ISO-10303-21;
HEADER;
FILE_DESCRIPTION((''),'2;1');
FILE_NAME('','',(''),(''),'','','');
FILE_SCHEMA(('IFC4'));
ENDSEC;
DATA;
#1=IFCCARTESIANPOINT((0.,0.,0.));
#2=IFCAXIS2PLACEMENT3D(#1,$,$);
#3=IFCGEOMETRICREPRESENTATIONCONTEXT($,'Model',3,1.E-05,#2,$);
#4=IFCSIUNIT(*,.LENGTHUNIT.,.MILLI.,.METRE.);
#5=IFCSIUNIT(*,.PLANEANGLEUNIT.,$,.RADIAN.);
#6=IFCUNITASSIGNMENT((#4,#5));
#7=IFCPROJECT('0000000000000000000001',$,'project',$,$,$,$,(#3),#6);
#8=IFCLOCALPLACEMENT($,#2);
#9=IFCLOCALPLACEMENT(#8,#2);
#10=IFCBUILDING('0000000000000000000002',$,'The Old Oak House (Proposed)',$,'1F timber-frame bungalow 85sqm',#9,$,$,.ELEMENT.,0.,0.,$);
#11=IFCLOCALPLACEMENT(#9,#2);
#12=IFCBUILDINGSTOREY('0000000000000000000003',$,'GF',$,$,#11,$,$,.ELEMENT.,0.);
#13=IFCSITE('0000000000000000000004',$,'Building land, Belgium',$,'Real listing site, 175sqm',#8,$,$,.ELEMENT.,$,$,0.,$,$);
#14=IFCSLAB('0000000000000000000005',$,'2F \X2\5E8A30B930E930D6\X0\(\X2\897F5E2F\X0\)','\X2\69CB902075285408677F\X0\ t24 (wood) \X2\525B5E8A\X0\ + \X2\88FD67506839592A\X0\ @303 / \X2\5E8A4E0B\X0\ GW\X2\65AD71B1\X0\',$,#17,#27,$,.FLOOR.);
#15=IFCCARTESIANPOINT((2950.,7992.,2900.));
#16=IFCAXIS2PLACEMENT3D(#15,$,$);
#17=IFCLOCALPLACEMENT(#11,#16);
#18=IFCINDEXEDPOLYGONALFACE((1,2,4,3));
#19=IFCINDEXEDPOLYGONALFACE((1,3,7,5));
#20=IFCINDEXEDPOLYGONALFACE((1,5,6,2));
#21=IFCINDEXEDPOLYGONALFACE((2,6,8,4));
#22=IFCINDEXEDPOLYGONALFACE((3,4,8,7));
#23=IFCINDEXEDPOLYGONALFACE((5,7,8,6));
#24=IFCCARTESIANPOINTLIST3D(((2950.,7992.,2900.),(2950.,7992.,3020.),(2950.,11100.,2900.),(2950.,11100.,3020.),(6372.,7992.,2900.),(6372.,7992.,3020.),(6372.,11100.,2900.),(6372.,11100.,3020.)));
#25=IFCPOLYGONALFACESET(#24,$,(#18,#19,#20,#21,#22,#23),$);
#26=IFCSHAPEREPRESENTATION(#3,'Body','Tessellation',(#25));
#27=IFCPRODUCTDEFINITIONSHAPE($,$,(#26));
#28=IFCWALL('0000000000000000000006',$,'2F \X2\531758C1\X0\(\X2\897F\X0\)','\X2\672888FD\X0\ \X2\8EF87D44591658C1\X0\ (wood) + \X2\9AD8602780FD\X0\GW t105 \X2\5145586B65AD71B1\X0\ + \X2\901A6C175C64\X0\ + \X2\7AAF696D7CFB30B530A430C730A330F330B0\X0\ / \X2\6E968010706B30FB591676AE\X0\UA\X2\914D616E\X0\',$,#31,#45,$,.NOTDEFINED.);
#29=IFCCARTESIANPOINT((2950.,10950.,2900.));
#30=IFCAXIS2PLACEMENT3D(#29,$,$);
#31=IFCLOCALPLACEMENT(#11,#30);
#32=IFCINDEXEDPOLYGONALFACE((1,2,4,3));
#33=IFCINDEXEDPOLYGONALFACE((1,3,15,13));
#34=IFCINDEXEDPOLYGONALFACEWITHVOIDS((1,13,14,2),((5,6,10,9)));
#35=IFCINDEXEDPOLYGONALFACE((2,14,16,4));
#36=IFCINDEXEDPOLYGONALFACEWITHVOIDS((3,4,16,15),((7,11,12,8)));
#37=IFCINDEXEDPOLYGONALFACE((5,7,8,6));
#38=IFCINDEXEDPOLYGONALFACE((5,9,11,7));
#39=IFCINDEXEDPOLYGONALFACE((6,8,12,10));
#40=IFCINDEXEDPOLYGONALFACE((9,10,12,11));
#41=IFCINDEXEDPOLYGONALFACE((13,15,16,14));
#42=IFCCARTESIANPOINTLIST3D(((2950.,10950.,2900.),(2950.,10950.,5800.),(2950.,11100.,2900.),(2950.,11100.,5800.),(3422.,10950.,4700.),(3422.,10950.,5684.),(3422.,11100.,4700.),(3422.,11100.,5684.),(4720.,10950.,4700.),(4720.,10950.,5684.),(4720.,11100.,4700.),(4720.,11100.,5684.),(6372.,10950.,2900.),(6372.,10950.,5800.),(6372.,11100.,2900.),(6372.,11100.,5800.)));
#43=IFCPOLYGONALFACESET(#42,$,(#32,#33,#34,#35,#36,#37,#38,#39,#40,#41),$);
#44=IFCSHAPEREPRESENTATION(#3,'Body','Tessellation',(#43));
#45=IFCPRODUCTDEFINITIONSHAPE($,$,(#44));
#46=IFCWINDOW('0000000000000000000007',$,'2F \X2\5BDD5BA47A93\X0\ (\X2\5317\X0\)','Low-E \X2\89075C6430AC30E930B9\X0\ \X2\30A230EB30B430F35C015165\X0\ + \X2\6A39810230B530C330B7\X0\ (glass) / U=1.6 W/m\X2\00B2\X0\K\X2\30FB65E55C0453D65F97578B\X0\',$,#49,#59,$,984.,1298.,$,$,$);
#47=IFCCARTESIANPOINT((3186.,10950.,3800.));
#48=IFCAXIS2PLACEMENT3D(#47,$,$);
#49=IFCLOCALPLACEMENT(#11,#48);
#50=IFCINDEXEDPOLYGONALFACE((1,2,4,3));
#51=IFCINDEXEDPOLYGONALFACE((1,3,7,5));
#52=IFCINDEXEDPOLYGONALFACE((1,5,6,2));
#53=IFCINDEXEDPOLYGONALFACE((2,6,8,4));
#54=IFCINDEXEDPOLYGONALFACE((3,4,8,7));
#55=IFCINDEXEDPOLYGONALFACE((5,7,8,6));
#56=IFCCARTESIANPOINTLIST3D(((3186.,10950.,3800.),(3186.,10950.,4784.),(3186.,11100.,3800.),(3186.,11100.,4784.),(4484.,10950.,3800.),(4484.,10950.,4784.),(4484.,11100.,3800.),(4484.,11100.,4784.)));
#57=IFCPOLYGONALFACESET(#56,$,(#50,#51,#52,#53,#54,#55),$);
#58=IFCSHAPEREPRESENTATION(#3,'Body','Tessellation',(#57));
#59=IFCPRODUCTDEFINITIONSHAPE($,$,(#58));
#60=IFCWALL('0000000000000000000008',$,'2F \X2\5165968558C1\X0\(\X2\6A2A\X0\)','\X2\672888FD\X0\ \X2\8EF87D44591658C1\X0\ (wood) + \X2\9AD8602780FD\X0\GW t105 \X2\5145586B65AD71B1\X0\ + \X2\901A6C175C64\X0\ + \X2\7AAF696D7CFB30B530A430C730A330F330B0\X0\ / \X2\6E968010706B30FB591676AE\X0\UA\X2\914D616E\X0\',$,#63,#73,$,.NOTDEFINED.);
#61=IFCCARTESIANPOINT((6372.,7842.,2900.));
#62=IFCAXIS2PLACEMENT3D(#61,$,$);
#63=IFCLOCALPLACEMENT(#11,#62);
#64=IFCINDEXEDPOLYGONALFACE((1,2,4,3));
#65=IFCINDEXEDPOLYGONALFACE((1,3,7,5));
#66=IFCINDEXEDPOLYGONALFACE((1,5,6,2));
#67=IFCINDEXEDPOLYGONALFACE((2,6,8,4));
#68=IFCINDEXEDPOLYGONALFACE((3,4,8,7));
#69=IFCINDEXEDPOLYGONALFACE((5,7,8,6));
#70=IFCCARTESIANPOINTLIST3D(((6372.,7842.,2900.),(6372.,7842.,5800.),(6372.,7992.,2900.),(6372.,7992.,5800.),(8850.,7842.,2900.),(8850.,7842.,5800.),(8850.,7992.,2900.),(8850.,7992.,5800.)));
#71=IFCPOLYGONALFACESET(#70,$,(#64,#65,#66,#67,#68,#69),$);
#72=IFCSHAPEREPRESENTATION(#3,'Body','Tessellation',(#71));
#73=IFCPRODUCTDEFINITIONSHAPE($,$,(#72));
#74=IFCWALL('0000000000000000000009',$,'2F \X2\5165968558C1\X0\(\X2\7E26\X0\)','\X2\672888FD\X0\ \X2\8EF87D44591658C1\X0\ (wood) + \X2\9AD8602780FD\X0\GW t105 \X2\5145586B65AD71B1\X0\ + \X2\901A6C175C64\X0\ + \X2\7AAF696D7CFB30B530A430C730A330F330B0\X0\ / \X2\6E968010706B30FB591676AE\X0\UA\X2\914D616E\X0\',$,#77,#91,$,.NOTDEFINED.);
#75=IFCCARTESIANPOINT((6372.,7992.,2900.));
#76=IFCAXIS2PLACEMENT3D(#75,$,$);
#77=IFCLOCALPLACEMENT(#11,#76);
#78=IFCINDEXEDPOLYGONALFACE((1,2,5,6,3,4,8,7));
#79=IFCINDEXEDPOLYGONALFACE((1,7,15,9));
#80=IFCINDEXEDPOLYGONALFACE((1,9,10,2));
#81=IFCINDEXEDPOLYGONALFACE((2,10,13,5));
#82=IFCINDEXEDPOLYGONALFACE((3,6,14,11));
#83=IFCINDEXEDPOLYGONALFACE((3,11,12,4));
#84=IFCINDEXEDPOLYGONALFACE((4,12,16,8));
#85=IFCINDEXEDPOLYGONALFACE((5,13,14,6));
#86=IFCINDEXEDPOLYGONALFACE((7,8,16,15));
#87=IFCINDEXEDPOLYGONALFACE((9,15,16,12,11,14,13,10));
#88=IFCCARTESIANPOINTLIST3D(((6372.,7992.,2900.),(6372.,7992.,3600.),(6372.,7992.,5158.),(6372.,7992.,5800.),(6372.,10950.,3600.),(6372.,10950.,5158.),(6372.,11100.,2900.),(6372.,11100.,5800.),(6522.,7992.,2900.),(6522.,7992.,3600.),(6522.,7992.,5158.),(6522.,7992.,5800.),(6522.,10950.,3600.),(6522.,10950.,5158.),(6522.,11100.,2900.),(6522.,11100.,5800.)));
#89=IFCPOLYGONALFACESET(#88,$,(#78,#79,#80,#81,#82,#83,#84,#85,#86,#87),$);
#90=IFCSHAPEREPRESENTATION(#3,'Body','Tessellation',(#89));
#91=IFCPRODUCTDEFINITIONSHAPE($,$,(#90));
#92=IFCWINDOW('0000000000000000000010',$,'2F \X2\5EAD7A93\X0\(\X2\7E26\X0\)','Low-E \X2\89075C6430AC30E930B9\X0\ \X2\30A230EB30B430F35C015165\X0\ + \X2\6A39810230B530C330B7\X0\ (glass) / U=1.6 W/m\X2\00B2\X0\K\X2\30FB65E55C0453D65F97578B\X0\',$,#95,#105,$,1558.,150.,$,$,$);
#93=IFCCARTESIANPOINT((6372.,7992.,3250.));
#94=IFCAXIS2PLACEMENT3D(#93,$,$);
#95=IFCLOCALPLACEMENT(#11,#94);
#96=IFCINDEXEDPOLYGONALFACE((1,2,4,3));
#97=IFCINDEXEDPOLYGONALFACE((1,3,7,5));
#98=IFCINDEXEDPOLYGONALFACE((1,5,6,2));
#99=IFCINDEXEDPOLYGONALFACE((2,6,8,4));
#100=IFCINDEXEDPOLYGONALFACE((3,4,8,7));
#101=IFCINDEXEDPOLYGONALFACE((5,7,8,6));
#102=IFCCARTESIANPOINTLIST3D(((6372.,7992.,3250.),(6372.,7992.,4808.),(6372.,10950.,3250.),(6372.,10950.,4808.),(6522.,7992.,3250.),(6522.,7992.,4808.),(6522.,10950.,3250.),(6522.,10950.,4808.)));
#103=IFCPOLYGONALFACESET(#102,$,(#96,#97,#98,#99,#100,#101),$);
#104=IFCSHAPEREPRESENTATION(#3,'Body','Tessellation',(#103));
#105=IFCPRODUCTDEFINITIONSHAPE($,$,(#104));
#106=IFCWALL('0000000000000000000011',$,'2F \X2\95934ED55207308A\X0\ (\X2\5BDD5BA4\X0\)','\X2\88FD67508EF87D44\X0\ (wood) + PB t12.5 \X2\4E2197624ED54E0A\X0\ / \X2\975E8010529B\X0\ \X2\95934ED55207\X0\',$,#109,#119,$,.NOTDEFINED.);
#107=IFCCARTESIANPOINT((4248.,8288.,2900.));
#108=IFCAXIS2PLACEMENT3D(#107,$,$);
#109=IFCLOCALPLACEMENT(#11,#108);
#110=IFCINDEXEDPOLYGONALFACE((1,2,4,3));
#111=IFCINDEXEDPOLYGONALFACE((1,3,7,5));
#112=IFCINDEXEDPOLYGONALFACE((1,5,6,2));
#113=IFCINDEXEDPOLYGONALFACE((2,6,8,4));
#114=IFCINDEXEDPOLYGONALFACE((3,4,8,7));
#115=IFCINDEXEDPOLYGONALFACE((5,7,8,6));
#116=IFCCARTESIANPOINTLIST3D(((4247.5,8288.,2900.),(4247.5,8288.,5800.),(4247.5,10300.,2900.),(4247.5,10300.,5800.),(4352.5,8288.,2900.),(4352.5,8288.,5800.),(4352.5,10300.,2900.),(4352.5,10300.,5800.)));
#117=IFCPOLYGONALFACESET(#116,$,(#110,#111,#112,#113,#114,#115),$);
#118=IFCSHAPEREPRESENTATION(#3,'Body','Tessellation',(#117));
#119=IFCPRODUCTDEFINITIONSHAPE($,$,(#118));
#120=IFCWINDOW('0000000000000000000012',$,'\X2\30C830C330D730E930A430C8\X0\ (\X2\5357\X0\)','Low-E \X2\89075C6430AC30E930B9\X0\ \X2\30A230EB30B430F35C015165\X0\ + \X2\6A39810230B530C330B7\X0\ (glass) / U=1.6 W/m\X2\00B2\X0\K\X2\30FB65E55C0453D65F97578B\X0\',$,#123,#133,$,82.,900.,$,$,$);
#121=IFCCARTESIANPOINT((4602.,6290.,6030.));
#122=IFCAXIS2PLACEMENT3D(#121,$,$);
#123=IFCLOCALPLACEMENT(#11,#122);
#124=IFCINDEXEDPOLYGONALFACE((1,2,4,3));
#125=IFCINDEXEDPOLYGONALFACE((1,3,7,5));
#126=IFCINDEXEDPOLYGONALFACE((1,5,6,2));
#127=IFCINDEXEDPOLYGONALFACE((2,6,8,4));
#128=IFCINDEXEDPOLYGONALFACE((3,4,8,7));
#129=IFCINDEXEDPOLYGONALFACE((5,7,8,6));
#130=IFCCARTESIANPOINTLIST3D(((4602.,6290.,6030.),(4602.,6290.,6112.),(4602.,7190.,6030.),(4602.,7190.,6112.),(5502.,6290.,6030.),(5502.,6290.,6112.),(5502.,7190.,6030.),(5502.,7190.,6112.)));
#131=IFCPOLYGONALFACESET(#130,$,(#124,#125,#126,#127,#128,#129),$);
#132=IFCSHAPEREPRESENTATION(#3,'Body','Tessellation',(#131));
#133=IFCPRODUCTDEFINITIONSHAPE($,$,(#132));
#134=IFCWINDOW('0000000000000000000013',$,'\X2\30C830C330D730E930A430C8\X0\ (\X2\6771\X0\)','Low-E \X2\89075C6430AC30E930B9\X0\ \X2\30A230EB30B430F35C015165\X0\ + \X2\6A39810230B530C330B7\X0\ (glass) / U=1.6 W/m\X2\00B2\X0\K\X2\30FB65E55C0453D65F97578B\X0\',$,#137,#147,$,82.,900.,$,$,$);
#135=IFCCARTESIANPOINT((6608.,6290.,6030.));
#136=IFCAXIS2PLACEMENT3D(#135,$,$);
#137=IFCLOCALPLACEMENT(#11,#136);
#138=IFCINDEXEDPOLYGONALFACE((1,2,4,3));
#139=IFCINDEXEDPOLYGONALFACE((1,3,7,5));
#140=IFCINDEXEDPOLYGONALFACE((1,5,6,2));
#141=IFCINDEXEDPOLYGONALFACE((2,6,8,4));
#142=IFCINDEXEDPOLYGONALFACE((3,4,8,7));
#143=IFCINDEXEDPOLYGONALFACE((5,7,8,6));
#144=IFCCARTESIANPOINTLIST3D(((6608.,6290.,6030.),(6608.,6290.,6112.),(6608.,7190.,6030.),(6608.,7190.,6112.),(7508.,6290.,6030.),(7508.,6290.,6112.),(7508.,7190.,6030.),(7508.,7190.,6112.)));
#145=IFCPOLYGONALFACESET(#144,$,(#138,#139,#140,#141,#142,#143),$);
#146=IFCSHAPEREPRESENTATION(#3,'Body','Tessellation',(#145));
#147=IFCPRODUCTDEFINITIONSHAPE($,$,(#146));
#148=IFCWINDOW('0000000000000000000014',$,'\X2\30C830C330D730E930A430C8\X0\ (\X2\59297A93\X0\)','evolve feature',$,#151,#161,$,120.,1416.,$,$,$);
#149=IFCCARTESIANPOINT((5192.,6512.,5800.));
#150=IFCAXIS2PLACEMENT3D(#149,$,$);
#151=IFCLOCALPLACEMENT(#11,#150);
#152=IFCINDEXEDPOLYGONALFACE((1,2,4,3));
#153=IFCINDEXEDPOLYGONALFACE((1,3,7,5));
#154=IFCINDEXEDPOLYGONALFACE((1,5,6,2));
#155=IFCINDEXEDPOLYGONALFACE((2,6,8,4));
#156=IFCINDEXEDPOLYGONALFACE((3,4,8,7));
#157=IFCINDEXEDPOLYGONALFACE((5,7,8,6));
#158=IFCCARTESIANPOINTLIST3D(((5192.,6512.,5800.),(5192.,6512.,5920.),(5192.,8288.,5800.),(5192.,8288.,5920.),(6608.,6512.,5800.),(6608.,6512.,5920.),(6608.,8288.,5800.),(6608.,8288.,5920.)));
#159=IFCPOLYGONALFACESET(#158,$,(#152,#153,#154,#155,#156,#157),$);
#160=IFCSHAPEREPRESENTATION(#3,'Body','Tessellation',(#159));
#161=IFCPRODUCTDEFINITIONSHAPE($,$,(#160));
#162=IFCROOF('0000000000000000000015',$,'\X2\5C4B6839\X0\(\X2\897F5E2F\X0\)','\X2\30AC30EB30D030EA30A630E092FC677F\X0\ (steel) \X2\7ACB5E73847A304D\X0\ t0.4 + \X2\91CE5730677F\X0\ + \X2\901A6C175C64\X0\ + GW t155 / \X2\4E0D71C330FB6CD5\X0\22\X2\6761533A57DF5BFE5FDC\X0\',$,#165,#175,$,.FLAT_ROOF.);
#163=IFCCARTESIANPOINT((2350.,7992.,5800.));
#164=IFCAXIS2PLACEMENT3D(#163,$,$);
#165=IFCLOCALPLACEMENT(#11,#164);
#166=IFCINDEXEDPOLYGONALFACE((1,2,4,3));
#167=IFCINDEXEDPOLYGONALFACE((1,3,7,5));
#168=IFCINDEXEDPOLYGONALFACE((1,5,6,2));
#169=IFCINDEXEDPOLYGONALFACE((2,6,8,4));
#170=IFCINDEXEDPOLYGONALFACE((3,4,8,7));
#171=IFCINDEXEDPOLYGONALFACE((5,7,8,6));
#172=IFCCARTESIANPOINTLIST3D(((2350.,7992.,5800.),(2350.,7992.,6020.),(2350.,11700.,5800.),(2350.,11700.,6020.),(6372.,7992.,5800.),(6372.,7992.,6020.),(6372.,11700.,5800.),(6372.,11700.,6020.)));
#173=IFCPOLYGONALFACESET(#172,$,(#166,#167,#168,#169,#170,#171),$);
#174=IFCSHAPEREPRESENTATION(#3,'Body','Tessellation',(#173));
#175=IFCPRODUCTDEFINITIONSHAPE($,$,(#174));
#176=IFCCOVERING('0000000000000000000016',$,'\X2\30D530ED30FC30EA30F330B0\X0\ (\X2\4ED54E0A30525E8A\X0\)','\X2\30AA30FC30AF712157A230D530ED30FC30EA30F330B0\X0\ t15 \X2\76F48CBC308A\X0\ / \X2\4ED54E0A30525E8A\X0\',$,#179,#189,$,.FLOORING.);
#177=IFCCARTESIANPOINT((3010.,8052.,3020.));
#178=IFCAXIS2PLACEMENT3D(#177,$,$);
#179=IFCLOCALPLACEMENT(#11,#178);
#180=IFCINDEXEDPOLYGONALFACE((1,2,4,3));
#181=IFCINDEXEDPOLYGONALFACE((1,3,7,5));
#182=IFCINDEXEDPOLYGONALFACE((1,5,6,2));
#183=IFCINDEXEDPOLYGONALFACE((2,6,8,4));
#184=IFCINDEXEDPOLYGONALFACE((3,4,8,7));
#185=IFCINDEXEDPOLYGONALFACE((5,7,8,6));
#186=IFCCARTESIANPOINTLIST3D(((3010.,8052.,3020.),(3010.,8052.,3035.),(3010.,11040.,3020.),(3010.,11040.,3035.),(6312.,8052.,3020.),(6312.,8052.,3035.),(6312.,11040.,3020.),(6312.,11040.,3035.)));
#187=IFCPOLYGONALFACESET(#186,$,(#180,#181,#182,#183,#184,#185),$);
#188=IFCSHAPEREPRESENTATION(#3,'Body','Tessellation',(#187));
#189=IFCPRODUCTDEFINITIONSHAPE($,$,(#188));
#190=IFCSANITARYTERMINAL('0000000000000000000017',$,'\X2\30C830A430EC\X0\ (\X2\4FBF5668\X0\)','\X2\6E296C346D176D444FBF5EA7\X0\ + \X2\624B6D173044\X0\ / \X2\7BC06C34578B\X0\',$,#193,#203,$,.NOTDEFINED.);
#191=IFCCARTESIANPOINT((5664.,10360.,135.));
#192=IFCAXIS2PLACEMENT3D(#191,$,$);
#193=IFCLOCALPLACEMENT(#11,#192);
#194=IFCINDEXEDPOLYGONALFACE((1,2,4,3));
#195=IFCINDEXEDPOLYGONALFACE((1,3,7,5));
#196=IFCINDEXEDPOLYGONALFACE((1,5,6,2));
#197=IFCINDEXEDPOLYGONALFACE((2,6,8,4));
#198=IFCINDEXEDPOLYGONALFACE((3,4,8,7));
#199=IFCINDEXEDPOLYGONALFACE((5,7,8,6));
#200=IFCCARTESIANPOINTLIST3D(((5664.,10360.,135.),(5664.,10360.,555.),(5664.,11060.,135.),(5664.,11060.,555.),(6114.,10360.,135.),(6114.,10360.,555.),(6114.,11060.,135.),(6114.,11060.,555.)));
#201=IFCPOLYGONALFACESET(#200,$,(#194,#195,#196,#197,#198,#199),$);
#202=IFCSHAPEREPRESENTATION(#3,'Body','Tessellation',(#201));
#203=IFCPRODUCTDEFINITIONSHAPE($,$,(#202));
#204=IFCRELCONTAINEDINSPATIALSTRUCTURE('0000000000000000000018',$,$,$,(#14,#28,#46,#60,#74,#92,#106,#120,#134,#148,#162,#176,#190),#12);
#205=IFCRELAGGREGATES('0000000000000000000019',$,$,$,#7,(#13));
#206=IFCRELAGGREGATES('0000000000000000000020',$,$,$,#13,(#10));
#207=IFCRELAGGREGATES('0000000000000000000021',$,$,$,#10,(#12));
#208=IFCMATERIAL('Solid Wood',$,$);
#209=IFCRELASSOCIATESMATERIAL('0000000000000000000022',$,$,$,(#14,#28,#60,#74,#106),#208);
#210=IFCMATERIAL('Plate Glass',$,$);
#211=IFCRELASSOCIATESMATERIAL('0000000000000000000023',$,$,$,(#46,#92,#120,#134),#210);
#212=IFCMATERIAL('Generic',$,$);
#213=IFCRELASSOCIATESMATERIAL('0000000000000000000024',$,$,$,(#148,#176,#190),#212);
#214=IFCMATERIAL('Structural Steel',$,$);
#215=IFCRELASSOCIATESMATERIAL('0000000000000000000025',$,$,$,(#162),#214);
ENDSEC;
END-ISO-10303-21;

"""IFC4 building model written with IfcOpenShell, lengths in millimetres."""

from ifc_helpers import new_model, si_unit, frame, frame_2d, origin, place, context, project, spatial, rectangle, extrude, material, element, fill, save


model = new_model("IFC4")

# Units and contexts
model_context = context("Model", 3, precision=1e-05, world=origin())
ifc_project = project(units=[si_unit("LENGTHUNIT", "METRE", prefix="MILLI"), si_unit("PLANEANGLEUNIT", "RADIAN")], contexts=[model_context])

# Site, building, storey
site_placement = place(None, origin())
site = spatial("IfcSite", under=ifc_project, at=site_placement, Name="Building land, Belgium", ObjectType="Real listing site, 175sqm", CompositionType="ELEMENT", RefElevation=0.0)
building_placement = place(site_placement, origin())
building = spatial("IfcBuilding", under=site, at=building_placement, Name="The Old Oak House (Proposed)", ObjectType="1F timber-frame bungalow 85sqm", CompositionType="ELEMENT", ElevationOfRefHeight=0.0, ElevationOfTerrain=0.0)
storey_placement = place(building_placement, origin())
storey = spatial("IfcBuildingStorey", under=building, at=storey_placement, Name="GF", CompositionType="ELEMENT", Elevation=0.0)

# Slab
ifc_material_1 = material(Name="Solid Wood")
slab_placement = place(storey_placement, frame((2950.0, 7992.0, 2900.0)))
element("IfcSlab", 1, at=slab_placement, inside=storey, material=ifc_material_1, Name="2F 床スラブ(西帯)", Description="構造用合板 t24 (wood) 剛床 + 製材根太 @303 / 床下 GW断熱", PredefinedType="FLOOR", context=model_context, shape_type="SweptSolid", body=[
    extrude(rectangle(XDim=3422.0, YDim=3108.0, at=frame_2d((1711.0, 1554.0))), frame((2950.0, 7992.0, 2900.0)), (0.0, 0.0, 1.0), 120.0),
])

# Wall, opening, window
wall_1_placement = place(storey_placement, frame((2950.0, 10950.0, 2900.0)))
wall_1 = element("IfcWall", 2, at=wall_1_placement, inside=storey, material=ifc_material_1, Name="2F 北壁(西)", Description="木製 軸組外壁 (wood) + 高性能GW t105 充填断熱 + 通気層 + 窯業系サイディング / 準耐火・外皮UA配慮", PredefinedType="NOTDEFINED", context=model_context, shape_type="SweptSolid", body=[
    extrude(rectangle(XDim=3422.0, YDim=150.0, at=frame_2d((1711.0, 75.0))), frame((2950.0, 10950.0, 2900.0)), (0.0, 0.0, 1.0), 2900.0),
])
opening_1_placement = place(storey_placement, frame((3186.0, 10950.0, 3800.0)))
opening_1 = element("IfcOpeningElement", 3, at=opening_1_placement, cuts=wall_1, PredefinedType="NOTDEFINED", context=model_context, shape_type="SweptSolid", body=[
    extrude(rectangle(XDim=1298.0, YDim=150.0, at=frame_2d((649.0, 75.0))), frame((3186.0, 10950.0, 3800.0)), (0.0, 0.0, 1.0), 984.0),
])
ifc_material_2 = material(Name="Plate Glass")
window_1_placement = place(storey_placement, frame((3186.0, 10950.0, 3800.0)))
window_1 = element("IfcWindow", 4, at=window_1_placement, inside=storey, material=ifc_material_2, Name="2F 寝室窓 (北)", Description="Low-E 複層ガラス アルゴン封入 + 樹脂サッシ (glass) / U=1.6 W/m²K・日射取得型", OverallHeight=984.0, OverallWidth=1298.0, context=model_context, shape_type="SweptSolid", body=[
    extrude(rectangle(XDim=1298.0, YDim=150.0, at=frame_2d((649.0, 75.0))), frame((3186.0, 10950.0, 3800.0)), (0.0, 0.0, 1.0), 984.0),
])
fill(opening_1, window_1)

# Wall
wall_2_placement = place(storey_placement, frame((6372.0, 7842.0, 2900.0)))
element("IfcWall", 5, at=wall_2_placement, inside=storey, material=ifc_material_1, Name="2F 入隅壁(横)", Description="木製 軸組外壁 (wood) + 高性能GW t105 充填断熱 + 通気層 + 窯業系サイディング / 準耐火・外皮UA配慮", PredefinedType="NOTDEFINED", context=model_context, shape_type="SweptSolid", body=[
    extrude(rectangle(XDim=2478.0, YDim=150.0, at=frame_2d((1239.0, 75.0))), frame((6372.0, 7842.0, 2900.0)), (0.0, 0.0, 1.0), 2900.0),
])

# Wall, opening, window
wall_3_placement = place(storey_placement, frame((6372.0, 7992.0, 2900.0)))
wall_3 = element("IfcWall", 6, at=wall_3_placement, inside=storey, material=ifc_material_1, Name="2F 入隅壁(縦)", Description="木製 軸組外壁 (wood) + 高性能GW t105 充填断熱 + 通気層 + 窯業系サイディング / 準耐火・外皮UA配慮", PredefinedType="NOTDEFINED", context=model_context, shape_type="SweptSolid", body=[
    extrude(rectangle(XDim=150.0, YDim=3108.0, at=frame_2d((75.0, 1554.0))), frame((6372.0, 7992.0, 2900.0)), (0.0, 0.0, 1.0), 2900.0),
])
opening_2_placement = place(storey_placement, frame((6372.0, 7992.0, 3250.0)))
opening_2 = element("IfcOpeningElement", 7, at=opening_2_placement, cuts=wall_3, PredefinedType="NOTDEFINED", context=model_context, shape_type="SweptSolid", body=[
    extrude(rectangle(XDim=150.0, YDim=2958.0, at=frame_2d((75.0, 1479.0))), frame((6372.0, 7992.0, 3250.0)), (0.0, 0.0, 1.0), 1558.0),
])
window_2_placement = place(storey_placement, frame((6372.0, 7992.0, 3250.0)))
window_2 = element("IfcWindow", 8, at=window_2_placement, inside=storey, material=ifc_material_2, Name="2F 庭窓(縦)", Description="Low-E 複層ガラス アルゴン封入 + 樹脂サッシ (glass) / U=1.6 W/m²K・日射取得型", OverallHeight=1558.0, OverallWidth=150.0, context=model_context, shape_type="SweptSolid", body=[
    extrude(rectangle(XDim=150.0, YDim=2958.0, at=frame_2d((75.0, 1479.0))), frame((6372.0, 7992.0, 3250.0)), (0.0, 0.0, 1.0), 1558.0),
])
fill(opening_2, window_2)

# Wall
wall_4_placement = place(storey_placement, frame((4248.0, 8288.0, 2900.0)))
element("IfcWall", 9, at=wall_4_placement, inside=storey, material=ifc_material_1, Name="2F 間仕切り (寝室)", Description="製材軸組 (wood) + PB t12.5 両面仕上 / 非耐力 間仕切", PredefinedType="NOTDEFINED", context=model_context, shape_type="SweptSolid", body=[
    extrude(rectangle(XDim=105.0, YDim=2012.0, at=frame_2d((52.0, 1006.0))), frame((4248.0, 8288.0, 2900.0)), (0.0, 0.0, 1.0), 2900.0),
])

# Windows
window_3_placement = place(storey_placement, frame((4602.0, 6290.0, 6030.0)))
element("IfcWindow", 10, at=window_3_placement, inside=storey, material=ifc_material_2, Name="トップライト (南)", Description="Low-E 複層ガラス アルゴン封入 + 樹脂サッシ (glass) / U=1.6 W/m²K・日射取得型", OverallHeight=82.0, OverallWidth=900.0, context=model_context, shape_type="SweptSolid", body=[
    extrude(rectangle(XDim=900.0, YDim=900.0, at=frame_2d((450.0, 450.0))), frame((4602.0, 6290.0, 6030.0)), (0.0, 0.0, 1.0), 82.0),
])
window_4_placement = place(storey_placement, frame((6608.0, 6290.0, 6030.0)))
element("IfcWindow", 11, at=window_4_placement, inside=storey, material=ifc_material_2, Name="トップライト (東)", Description="Low-E 複層ガラス アルゴン封入 + 樹脂サッシ (glass) / U=1.6 W/m²K・日射取得型", OverallHeight=82.0, OverallWidth=900.0, context=model_context, shape_type="SweptSolid", body=[
    extrude(rectangle(XDim=900.0, YDim=900.0, at=frame_2d((450.0, 450.0))), frame((6608.0, 6290.0, 6030.0)), (0.0, 0.0, 1.0), 82.0),
])
ifc_material_3 = material(Name="Generic")
window_5_placement = place(storey_placement, frame((5192.0, 6512.0, 5800.0)))
element("IfcWindow", 12, at=window_5_placement, inside=storey, material=ifc_material_3, Name="トップライト (天窓)", Description="evolve feature", OverallHeight=120.0, OverallWidth=1416.0, context=model_context, shape_type="SweptSolid", body=[
    extrude(rectangle(XDim=1416.0, YDim=1776.0, at=frame_2d((708.0, 888.0))), frame((5192.0, 6512.0, 5800.0)), (0.0, 0.0, 1.0), 120.0),
])

# Roof
ifc_material_4 = material(Name="Structural Steel")
for number, where, name in (
    (13, (2350.0, 7992.0, 5800.0), "屋根(西帯)"),
):
    element("IfcRoof", number, at=place(storey_placement, frame(where)), inside=storey, material=ifc_material_4, Name=name, Description="ガルバリウム鋼板 (steel) 立平葺き t0.4 + 野地板 + 通気層 + GW t155 / 不燃・法22条区域対応", PredefinedType="FLAT_ROOF", context=model_context, shape_type="SweptSolid", body=[
        extrude(rectangle(XDim=4022.0, YDim=3708.0, at=frame_2d((2011.0, 1854.0))), frame((2350.0, 7992.0, 5800.0)), (0.0, 0.0, 1.0), 220.0),
    ])

# Covering
covering_placement = place(storey_placement, frame((3010.0, 8052.0, 3020.0)))
element("IfcCovering", 14, at=covering_placement, inside=storey, material=ifc_material_3, Name="フローリング (仕上げ床)", Description="オーク無垢フローリング t15 直貼り / 仕上げ床", PredefinedType="FLOORING", context=model_context, shape_type="SweptSolid", body=[
    extrude(rectangle(XDim=3302.0, YDim=2988.0, at=frame_2d((1651.0, 1494.0))), frame((3010.0, 8052.0, 3020.0)), (0.0, 0.0, 1.0), 15.0),
])

# Sanitary terminal
sanitary_terminal_placement = place(storey_placement, frame((5664.0, 10360.0, 135.0)))
element("IfcSanitaryTerminal", 15, at=sanitary_terminal_placement, inside=storey, material=ifc_material_3, Name="トイレ (便器)", Description="温水洗浄便座 + 手洗い / 節水型", PredefinedType="NOTDEFINED", context=model_context, shape_type="SweptSolid", body=[
    extrude(rectangle(XDim=450.0, YDim=700.0, at=frame_2d((225.0, 350.0))), frame((5664.0, 10360.0, 135.0)), (0.0, 0.0, 1.0), 420.0),
])

save(model, "model.ifc")
